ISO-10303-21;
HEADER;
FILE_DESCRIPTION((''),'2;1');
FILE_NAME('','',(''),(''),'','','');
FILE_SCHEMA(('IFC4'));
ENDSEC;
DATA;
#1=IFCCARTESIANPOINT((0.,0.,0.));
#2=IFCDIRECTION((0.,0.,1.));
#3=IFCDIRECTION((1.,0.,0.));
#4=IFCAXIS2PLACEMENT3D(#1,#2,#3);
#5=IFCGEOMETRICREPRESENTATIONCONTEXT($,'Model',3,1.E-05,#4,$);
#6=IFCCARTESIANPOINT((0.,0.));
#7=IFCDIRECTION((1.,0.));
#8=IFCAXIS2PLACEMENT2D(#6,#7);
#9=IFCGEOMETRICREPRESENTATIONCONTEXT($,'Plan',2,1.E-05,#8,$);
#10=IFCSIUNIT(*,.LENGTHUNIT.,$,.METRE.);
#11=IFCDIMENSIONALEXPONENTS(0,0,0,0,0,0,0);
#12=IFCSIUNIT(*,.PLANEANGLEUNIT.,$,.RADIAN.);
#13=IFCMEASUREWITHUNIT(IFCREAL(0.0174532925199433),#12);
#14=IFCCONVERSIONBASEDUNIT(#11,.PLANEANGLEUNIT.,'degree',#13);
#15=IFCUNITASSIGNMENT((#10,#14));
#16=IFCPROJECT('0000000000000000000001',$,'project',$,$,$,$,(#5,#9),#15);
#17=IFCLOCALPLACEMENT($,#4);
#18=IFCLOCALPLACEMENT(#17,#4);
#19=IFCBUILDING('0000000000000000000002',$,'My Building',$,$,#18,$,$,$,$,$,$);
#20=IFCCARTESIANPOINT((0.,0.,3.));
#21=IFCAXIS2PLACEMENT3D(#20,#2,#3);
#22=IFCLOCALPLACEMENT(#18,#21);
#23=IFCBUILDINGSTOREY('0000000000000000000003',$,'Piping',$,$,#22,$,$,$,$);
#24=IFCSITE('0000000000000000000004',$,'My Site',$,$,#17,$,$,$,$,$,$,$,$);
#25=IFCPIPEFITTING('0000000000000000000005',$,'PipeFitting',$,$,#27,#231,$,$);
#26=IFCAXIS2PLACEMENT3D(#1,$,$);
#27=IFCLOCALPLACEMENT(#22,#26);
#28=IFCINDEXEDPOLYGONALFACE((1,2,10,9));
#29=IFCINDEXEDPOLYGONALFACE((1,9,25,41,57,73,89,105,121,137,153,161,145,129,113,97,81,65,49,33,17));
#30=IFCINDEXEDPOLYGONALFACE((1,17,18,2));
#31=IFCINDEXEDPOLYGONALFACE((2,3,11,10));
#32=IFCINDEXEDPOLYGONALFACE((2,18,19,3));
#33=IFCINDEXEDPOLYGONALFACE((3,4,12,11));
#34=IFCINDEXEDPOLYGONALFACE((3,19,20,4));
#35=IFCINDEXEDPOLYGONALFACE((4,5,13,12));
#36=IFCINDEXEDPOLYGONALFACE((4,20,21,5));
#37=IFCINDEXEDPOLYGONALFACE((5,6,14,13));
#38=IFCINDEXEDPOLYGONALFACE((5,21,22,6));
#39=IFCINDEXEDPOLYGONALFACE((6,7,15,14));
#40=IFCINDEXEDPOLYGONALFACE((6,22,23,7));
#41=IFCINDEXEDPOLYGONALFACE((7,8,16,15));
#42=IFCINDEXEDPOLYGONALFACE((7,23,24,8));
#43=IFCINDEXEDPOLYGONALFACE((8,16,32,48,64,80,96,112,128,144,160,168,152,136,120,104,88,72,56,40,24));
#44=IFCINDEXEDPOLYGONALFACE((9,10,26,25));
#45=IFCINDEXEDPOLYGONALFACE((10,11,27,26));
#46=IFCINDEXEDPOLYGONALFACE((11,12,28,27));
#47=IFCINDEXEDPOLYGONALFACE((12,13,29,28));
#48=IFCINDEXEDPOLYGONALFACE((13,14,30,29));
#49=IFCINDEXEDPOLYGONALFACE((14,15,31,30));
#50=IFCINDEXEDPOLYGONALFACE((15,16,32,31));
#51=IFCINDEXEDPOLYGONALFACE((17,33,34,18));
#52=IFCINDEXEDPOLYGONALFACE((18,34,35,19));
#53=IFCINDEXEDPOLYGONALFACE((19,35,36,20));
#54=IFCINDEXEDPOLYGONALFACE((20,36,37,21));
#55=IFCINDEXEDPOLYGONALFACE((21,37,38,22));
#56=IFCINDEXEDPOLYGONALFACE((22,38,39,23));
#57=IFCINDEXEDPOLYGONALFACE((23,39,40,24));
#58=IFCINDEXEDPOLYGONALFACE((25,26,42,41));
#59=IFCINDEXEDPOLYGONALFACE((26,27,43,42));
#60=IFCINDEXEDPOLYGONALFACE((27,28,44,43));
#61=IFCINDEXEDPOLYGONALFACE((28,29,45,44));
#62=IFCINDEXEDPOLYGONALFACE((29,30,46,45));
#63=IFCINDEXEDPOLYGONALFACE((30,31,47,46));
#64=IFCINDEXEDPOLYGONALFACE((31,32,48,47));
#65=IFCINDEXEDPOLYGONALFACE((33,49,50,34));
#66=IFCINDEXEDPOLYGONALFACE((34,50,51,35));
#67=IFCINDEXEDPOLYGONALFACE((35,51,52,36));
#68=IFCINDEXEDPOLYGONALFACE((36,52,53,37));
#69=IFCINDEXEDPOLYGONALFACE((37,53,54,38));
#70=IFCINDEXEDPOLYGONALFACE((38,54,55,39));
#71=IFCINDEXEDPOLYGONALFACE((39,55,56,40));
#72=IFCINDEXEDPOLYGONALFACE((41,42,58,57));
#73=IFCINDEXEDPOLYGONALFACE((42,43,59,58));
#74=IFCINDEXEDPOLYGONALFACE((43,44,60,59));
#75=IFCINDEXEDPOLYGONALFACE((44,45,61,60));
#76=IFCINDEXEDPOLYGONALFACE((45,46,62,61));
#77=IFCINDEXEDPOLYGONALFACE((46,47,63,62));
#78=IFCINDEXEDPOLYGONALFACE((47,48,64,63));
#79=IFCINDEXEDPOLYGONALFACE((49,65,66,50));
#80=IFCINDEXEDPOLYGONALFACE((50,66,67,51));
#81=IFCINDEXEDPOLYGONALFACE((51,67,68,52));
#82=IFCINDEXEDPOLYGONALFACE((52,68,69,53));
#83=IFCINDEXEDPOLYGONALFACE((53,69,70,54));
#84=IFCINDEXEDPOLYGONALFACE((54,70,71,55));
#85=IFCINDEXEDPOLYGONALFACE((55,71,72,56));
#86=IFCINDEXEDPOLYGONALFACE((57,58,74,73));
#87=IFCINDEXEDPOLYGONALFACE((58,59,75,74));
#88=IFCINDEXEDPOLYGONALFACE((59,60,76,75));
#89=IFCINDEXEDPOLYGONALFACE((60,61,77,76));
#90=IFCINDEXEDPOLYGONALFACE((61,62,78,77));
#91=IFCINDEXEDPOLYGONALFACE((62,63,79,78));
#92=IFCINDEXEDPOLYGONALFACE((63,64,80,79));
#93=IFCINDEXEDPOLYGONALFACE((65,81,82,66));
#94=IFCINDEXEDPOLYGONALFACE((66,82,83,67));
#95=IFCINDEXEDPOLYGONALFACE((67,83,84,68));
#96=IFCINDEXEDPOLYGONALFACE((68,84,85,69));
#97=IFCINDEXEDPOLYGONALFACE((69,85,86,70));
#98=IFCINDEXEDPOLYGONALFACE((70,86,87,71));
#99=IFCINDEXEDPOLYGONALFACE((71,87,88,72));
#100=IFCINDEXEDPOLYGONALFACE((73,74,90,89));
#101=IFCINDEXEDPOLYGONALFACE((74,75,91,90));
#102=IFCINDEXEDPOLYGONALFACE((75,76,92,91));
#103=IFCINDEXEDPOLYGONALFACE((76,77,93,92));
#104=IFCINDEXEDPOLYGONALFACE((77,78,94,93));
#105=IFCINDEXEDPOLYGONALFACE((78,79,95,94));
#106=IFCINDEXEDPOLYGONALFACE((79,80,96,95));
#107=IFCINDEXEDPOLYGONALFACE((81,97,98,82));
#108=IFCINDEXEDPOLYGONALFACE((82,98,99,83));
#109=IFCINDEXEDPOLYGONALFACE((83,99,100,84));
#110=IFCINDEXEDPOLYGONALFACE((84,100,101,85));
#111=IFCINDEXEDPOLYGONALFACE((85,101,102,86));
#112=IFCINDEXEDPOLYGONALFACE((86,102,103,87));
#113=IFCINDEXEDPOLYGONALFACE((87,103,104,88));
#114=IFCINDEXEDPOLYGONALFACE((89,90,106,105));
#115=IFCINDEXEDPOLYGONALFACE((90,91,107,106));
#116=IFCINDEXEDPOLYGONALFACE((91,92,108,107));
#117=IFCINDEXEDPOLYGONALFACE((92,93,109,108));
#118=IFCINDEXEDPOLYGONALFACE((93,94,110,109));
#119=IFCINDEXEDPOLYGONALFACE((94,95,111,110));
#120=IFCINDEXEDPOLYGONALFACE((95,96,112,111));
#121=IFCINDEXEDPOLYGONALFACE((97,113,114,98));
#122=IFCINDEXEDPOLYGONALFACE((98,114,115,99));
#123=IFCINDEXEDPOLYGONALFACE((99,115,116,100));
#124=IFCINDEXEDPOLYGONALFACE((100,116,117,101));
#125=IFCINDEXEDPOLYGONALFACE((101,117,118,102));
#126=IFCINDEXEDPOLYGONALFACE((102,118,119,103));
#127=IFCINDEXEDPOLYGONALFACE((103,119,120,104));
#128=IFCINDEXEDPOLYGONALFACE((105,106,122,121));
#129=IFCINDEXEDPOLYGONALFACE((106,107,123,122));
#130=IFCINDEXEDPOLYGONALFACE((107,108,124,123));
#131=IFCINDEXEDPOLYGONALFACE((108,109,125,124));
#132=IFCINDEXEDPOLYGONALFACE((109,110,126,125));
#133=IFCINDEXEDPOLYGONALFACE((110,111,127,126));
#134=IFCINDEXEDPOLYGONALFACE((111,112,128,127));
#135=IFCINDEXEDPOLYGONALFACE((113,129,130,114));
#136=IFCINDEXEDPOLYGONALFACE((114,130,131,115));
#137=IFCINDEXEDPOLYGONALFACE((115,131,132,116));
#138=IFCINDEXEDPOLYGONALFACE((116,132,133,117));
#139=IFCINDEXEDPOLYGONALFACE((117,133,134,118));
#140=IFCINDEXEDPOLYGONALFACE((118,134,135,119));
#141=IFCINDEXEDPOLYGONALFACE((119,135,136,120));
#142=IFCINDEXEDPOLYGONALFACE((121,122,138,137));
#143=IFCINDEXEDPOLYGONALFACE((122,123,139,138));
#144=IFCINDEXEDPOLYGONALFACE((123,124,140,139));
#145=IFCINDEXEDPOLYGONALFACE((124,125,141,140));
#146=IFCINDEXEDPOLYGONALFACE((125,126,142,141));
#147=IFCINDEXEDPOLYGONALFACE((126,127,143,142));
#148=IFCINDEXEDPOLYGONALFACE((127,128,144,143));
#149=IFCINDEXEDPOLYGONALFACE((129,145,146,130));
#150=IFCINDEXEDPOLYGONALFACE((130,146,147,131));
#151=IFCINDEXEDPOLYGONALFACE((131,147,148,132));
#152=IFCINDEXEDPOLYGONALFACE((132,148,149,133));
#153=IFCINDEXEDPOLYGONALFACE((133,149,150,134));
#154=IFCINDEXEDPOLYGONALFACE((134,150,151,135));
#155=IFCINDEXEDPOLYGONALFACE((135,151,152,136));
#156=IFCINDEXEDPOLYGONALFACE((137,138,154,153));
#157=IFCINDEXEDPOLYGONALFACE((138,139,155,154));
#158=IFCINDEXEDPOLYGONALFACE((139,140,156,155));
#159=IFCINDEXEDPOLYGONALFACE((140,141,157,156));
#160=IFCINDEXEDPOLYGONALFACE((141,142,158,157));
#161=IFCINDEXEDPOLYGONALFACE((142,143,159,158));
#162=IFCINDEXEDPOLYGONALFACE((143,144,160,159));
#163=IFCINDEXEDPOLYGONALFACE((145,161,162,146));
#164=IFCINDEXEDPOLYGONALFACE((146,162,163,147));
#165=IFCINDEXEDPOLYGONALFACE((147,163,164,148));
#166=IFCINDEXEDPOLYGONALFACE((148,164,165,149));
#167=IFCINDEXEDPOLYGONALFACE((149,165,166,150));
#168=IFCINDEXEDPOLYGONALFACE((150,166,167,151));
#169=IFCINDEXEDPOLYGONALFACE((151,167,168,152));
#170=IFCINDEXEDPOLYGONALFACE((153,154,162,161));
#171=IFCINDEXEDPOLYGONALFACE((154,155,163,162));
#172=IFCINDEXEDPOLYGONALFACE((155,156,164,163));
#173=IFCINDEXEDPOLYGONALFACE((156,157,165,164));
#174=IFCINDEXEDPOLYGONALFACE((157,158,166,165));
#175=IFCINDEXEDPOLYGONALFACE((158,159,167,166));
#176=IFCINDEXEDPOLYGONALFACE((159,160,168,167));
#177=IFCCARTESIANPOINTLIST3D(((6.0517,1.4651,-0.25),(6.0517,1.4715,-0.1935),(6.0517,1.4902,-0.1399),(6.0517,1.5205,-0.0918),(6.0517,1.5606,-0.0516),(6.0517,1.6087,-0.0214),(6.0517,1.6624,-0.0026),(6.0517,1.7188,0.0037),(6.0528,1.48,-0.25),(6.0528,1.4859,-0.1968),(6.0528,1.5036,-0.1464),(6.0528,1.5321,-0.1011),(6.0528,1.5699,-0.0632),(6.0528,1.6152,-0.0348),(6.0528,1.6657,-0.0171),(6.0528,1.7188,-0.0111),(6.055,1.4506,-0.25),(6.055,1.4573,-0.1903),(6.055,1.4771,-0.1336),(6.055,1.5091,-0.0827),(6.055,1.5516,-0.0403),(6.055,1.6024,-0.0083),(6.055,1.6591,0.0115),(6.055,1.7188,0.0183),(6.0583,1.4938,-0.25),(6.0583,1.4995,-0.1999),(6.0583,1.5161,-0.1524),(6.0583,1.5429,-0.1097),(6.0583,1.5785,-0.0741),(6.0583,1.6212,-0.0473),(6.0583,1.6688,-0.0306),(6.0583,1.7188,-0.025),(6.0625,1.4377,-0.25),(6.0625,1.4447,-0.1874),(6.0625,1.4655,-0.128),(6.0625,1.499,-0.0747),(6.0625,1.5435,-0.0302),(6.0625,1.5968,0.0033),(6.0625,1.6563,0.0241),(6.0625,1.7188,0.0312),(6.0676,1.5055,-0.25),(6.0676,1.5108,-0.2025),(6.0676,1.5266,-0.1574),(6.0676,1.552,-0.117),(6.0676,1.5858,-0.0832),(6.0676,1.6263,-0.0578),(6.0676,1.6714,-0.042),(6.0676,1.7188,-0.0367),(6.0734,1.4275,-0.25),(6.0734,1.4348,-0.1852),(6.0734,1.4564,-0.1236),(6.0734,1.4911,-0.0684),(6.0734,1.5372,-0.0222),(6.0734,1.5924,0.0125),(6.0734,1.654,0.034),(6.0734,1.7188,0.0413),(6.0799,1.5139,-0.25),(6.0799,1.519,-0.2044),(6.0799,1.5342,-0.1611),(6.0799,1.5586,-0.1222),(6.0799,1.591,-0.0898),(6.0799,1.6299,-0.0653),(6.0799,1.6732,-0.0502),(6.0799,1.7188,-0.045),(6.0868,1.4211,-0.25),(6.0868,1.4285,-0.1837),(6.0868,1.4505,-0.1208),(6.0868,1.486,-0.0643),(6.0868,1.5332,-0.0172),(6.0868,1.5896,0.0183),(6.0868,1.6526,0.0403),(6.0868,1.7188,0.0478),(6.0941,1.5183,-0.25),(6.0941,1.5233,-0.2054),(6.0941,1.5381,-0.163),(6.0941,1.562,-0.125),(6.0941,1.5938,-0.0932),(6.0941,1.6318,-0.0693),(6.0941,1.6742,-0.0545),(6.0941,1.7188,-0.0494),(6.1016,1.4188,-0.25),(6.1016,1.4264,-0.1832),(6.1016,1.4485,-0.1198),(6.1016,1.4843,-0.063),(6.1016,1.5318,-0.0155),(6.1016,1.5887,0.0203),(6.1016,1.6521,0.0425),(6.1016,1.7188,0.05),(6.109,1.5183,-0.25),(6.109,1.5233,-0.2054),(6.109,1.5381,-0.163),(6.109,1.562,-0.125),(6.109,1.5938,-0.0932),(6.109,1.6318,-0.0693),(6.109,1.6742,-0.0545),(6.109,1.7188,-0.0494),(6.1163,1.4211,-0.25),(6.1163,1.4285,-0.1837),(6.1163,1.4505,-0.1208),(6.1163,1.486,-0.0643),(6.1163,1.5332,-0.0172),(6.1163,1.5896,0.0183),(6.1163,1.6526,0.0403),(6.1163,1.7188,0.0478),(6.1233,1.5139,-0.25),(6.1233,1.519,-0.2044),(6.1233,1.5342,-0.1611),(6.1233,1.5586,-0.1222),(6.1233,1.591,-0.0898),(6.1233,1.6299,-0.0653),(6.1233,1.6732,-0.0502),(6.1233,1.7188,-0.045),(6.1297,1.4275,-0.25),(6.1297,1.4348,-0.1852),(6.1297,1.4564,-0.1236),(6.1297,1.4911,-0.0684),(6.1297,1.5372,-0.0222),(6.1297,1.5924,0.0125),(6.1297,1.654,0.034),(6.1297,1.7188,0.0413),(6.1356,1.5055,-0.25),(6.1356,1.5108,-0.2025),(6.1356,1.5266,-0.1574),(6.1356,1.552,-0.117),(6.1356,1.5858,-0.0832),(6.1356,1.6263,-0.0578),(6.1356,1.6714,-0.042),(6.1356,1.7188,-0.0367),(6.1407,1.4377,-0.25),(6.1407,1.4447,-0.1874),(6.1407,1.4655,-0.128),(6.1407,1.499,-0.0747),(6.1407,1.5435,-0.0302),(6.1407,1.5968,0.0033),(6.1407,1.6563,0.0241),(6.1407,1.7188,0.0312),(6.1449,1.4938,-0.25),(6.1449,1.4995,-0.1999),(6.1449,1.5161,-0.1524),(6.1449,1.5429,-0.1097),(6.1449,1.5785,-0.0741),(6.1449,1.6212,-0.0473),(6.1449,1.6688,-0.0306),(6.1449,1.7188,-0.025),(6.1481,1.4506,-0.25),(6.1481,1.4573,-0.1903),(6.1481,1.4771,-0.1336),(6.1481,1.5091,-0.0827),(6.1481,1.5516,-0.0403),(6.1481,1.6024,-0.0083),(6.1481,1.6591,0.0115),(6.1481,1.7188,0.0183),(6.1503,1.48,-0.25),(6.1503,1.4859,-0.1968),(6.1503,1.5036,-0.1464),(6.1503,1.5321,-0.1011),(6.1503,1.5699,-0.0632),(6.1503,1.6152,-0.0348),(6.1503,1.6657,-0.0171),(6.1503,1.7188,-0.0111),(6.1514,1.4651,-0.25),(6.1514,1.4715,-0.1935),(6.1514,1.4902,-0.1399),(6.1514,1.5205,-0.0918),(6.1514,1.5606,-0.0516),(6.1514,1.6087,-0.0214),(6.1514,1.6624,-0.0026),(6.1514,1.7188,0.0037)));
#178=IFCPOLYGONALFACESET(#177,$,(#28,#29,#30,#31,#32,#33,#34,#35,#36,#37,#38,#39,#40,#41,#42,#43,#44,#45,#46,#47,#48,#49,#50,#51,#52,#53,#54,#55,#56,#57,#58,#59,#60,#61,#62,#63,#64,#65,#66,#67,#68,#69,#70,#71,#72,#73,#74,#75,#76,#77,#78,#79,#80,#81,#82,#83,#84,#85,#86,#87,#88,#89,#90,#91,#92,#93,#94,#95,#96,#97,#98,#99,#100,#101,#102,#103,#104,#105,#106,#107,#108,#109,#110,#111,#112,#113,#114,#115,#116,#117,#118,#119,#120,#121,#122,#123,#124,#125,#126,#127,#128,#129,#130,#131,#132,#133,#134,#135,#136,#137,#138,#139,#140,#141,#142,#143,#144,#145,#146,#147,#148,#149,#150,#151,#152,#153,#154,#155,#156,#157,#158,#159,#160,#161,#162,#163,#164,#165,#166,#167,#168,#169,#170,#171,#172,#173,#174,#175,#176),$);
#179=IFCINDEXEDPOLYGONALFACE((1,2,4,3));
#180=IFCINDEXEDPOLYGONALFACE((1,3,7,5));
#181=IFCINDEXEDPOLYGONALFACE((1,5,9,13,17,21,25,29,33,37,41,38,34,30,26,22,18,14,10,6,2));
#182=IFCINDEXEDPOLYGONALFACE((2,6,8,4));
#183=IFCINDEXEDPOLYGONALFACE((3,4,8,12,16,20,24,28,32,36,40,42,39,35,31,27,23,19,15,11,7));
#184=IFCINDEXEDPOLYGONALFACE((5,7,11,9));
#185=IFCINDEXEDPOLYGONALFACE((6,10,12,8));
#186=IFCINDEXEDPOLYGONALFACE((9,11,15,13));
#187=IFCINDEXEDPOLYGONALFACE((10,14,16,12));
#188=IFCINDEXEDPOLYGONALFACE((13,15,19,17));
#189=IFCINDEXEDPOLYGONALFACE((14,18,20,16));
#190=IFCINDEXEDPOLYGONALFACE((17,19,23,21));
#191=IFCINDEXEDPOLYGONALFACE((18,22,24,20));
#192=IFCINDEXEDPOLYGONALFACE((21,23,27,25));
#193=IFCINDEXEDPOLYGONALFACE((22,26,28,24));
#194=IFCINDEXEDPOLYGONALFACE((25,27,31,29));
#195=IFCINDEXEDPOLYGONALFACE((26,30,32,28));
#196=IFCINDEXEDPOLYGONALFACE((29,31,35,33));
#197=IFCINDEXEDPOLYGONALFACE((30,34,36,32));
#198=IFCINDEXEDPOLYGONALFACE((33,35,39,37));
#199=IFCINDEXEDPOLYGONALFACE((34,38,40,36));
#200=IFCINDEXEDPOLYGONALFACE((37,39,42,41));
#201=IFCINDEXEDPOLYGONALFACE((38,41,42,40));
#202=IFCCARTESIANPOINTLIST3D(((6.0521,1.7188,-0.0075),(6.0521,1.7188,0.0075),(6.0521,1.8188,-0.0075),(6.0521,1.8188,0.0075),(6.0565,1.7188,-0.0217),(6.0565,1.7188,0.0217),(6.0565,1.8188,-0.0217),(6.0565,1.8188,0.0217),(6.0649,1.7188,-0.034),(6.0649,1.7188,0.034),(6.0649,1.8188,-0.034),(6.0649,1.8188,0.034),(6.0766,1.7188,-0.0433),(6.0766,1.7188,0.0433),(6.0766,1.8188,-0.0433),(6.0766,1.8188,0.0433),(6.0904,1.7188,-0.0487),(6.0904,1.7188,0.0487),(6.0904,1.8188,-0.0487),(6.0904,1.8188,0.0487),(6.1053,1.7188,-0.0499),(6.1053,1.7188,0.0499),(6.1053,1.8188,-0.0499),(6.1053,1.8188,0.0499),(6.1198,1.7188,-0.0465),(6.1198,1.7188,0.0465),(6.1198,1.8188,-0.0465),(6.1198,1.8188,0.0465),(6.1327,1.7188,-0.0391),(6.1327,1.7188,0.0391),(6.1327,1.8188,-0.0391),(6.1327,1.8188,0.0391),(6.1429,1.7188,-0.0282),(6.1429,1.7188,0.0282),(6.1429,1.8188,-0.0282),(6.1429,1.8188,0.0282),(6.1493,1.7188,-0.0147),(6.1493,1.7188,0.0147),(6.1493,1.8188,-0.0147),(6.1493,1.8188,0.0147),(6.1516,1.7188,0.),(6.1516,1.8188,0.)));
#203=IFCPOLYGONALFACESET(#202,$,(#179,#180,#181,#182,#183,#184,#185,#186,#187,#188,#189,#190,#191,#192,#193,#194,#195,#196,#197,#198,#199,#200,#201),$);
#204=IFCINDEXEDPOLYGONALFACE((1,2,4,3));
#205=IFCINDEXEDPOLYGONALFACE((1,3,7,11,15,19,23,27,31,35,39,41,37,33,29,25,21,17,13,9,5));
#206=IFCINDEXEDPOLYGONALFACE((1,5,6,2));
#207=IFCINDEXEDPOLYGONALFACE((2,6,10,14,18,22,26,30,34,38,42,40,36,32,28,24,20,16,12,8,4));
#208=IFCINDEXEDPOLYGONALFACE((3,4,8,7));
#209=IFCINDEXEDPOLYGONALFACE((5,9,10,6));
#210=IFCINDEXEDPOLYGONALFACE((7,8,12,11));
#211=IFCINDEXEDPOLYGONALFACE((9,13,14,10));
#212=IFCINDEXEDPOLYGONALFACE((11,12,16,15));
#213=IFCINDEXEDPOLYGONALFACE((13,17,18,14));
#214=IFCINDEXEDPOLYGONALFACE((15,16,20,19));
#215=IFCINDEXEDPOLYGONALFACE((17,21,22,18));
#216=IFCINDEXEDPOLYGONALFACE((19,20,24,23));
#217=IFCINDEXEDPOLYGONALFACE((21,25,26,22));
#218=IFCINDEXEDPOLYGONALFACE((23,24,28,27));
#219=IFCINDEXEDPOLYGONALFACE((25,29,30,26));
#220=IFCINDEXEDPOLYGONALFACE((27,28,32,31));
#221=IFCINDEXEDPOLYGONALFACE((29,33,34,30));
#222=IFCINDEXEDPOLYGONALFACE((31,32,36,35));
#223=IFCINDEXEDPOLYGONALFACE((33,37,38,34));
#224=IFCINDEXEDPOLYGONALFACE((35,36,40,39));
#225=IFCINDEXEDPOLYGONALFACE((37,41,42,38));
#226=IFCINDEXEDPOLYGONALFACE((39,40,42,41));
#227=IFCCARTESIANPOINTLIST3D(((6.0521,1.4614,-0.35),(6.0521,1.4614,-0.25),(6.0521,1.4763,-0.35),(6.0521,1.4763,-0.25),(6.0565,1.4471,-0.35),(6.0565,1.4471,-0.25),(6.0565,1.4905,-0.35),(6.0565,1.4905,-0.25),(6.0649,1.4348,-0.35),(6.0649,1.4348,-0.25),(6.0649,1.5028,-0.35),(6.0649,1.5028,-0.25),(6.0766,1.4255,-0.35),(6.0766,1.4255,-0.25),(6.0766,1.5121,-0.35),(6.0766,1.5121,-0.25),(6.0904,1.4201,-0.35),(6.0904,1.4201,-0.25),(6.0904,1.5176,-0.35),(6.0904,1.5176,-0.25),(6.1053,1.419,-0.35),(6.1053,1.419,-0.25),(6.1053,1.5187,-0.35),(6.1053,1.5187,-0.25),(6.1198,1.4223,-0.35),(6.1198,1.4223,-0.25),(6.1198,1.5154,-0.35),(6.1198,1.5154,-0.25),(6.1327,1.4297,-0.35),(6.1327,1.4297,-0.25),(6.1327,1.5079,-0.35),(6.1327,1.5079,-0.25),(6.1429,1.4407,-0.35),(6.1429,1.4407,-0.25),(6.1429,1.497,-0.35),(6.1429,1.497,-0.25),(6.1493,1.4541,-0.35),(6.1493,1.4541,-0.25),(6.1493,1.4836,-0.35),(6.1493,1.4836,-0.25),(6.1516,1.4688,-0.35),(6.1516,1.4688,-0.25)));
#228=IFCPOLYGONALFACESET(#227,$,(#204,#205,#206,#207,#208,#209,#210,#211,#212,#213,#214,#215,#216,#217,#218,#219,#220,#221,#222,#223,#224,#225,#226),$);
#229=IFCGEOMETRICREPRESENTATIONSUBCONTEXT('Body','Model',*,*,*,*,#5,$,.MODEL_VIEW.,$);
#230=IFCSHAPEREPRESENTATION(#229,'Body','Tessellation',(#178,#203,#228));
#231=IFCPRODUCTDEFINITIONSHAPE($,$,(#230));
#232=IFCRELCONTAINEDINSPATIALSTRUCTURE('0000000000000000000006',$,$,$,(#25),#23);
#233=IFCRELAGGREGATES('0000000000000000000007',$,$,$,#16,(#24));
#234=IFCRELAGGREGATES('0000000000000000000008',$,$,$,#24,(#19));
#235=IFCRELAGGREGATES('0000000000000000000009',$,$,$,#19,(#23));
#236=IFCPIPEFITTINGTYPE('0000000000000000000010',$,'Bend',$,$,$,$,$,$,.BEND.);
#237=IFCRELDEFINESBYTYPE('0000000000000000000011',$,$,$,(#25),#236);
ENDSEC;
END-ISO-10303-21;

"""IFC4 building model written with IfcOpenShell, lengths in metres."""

from ifc_helpers import new_model, entity, si_unit, converted_unit, frame, origin_with_axes, origin_2d_with_axis, place, context, subcontext, project, spatial, circle, extrude, source, transform, mapped, type_object, type_shapes, element, save


model = new_model("IFC4")

# Units and contexts
model_context = context("Model", 3, precision=1e-05, world=origin_with_axes())
plan_context = context("Plan", 2, precision=1e-05, world=origin_2d_with_axis())
body_context = subcontext(model_context, "Body", "Model", "MODEL_VIEW")
ifc_project = project(units=[si_unit("LENGTHUNIT", "METRE"), converted_unit("PLANEANGLEUNIT", "degree", entity("IfcReal", 0.0174532925199433), si_unit("PLANEANGLEUNIT", "RADIAN"), dimensions=[0, 0, 0, 0, 0, 0, 0])], contexts=[model_context, plan_context])

# Site, building, storey
site_placement = place(None, origin_with_axes())
site = spatial("IfcSite", under=ifc_project, at=site_placement, Name="My Site")
building_placement = place(site_placement, origin_with_axes())
building = spatial("IfcBuilding", under=site, at=building_placement, Name="My Building")
storey_placement = place(building_placement, frame((0.0, 0.0, 3.0), z_axis=(0.0, 0.0, 1.0), x_axis=(1.0, 0.0, 0.0)))
storey = spatial("IfcBuildingStorey", under=building, at=storey_placement, Name="Piping")

# Pipe fitting
pipe_fitting_type = type_object("IfcPipeFittingType", Name="Bend", PredefinedType="BEND")
shared_shape = source(origin_with_axes(), body_context, "Body", "SolidModel", [
    entity("IfcSweptDiskSolid", entity("IfcIndexedPolyCurve", entity("IfcCartesianPointList3D", [[0.0, 0.0, -0.1], [0.0, 0.0732, -0.2768], [0.0, 0.25, -0.35]]), [entity("IfcArcIndex", [1, 2, 3])]), 0.05),
    extrude(circle(Radius=0.05), origin_with_axes(), (0.0, 0.0, -1.0), 0.1),
    extrude(circle(Radius=0.05), frame((0.0, 0.25, -0.35), z_axis=(0.0, 1.0, 0.0), x_axis=(1.0, 0.0, 0.0)), (0.0, 0.0, 1.0), 0.1),
])
type_shapes(pipe_fitting_type, [shared_shape])
for number, where, z_axis, x_axis, name in (
    (1, (6.1016, 1.8188, 0.0), (0.0, 1.0, 0.0), (1.0, 0.0, 0.0), "PipeFitting"),
):
    element("IfcPipeFitting", number, at=place(storey_placement, frame(where, z_axis=z_axis, x_axis=x_axis)), inside=storey, type_object=pipe_fitting_type, Name=name, context=body_context, shape_type="MappedRepresentation", body=[
        mapped(shared_shape, transform((0.0, 0.0, 0.0), x_axis=(1.0, 0.0, 0.0), y_axis=(0.0, 1.0, 0.0), z_axis=(0.0, 0.0, 1.0), scale=1.0)),
    ])

save(model, "model.ifc")
